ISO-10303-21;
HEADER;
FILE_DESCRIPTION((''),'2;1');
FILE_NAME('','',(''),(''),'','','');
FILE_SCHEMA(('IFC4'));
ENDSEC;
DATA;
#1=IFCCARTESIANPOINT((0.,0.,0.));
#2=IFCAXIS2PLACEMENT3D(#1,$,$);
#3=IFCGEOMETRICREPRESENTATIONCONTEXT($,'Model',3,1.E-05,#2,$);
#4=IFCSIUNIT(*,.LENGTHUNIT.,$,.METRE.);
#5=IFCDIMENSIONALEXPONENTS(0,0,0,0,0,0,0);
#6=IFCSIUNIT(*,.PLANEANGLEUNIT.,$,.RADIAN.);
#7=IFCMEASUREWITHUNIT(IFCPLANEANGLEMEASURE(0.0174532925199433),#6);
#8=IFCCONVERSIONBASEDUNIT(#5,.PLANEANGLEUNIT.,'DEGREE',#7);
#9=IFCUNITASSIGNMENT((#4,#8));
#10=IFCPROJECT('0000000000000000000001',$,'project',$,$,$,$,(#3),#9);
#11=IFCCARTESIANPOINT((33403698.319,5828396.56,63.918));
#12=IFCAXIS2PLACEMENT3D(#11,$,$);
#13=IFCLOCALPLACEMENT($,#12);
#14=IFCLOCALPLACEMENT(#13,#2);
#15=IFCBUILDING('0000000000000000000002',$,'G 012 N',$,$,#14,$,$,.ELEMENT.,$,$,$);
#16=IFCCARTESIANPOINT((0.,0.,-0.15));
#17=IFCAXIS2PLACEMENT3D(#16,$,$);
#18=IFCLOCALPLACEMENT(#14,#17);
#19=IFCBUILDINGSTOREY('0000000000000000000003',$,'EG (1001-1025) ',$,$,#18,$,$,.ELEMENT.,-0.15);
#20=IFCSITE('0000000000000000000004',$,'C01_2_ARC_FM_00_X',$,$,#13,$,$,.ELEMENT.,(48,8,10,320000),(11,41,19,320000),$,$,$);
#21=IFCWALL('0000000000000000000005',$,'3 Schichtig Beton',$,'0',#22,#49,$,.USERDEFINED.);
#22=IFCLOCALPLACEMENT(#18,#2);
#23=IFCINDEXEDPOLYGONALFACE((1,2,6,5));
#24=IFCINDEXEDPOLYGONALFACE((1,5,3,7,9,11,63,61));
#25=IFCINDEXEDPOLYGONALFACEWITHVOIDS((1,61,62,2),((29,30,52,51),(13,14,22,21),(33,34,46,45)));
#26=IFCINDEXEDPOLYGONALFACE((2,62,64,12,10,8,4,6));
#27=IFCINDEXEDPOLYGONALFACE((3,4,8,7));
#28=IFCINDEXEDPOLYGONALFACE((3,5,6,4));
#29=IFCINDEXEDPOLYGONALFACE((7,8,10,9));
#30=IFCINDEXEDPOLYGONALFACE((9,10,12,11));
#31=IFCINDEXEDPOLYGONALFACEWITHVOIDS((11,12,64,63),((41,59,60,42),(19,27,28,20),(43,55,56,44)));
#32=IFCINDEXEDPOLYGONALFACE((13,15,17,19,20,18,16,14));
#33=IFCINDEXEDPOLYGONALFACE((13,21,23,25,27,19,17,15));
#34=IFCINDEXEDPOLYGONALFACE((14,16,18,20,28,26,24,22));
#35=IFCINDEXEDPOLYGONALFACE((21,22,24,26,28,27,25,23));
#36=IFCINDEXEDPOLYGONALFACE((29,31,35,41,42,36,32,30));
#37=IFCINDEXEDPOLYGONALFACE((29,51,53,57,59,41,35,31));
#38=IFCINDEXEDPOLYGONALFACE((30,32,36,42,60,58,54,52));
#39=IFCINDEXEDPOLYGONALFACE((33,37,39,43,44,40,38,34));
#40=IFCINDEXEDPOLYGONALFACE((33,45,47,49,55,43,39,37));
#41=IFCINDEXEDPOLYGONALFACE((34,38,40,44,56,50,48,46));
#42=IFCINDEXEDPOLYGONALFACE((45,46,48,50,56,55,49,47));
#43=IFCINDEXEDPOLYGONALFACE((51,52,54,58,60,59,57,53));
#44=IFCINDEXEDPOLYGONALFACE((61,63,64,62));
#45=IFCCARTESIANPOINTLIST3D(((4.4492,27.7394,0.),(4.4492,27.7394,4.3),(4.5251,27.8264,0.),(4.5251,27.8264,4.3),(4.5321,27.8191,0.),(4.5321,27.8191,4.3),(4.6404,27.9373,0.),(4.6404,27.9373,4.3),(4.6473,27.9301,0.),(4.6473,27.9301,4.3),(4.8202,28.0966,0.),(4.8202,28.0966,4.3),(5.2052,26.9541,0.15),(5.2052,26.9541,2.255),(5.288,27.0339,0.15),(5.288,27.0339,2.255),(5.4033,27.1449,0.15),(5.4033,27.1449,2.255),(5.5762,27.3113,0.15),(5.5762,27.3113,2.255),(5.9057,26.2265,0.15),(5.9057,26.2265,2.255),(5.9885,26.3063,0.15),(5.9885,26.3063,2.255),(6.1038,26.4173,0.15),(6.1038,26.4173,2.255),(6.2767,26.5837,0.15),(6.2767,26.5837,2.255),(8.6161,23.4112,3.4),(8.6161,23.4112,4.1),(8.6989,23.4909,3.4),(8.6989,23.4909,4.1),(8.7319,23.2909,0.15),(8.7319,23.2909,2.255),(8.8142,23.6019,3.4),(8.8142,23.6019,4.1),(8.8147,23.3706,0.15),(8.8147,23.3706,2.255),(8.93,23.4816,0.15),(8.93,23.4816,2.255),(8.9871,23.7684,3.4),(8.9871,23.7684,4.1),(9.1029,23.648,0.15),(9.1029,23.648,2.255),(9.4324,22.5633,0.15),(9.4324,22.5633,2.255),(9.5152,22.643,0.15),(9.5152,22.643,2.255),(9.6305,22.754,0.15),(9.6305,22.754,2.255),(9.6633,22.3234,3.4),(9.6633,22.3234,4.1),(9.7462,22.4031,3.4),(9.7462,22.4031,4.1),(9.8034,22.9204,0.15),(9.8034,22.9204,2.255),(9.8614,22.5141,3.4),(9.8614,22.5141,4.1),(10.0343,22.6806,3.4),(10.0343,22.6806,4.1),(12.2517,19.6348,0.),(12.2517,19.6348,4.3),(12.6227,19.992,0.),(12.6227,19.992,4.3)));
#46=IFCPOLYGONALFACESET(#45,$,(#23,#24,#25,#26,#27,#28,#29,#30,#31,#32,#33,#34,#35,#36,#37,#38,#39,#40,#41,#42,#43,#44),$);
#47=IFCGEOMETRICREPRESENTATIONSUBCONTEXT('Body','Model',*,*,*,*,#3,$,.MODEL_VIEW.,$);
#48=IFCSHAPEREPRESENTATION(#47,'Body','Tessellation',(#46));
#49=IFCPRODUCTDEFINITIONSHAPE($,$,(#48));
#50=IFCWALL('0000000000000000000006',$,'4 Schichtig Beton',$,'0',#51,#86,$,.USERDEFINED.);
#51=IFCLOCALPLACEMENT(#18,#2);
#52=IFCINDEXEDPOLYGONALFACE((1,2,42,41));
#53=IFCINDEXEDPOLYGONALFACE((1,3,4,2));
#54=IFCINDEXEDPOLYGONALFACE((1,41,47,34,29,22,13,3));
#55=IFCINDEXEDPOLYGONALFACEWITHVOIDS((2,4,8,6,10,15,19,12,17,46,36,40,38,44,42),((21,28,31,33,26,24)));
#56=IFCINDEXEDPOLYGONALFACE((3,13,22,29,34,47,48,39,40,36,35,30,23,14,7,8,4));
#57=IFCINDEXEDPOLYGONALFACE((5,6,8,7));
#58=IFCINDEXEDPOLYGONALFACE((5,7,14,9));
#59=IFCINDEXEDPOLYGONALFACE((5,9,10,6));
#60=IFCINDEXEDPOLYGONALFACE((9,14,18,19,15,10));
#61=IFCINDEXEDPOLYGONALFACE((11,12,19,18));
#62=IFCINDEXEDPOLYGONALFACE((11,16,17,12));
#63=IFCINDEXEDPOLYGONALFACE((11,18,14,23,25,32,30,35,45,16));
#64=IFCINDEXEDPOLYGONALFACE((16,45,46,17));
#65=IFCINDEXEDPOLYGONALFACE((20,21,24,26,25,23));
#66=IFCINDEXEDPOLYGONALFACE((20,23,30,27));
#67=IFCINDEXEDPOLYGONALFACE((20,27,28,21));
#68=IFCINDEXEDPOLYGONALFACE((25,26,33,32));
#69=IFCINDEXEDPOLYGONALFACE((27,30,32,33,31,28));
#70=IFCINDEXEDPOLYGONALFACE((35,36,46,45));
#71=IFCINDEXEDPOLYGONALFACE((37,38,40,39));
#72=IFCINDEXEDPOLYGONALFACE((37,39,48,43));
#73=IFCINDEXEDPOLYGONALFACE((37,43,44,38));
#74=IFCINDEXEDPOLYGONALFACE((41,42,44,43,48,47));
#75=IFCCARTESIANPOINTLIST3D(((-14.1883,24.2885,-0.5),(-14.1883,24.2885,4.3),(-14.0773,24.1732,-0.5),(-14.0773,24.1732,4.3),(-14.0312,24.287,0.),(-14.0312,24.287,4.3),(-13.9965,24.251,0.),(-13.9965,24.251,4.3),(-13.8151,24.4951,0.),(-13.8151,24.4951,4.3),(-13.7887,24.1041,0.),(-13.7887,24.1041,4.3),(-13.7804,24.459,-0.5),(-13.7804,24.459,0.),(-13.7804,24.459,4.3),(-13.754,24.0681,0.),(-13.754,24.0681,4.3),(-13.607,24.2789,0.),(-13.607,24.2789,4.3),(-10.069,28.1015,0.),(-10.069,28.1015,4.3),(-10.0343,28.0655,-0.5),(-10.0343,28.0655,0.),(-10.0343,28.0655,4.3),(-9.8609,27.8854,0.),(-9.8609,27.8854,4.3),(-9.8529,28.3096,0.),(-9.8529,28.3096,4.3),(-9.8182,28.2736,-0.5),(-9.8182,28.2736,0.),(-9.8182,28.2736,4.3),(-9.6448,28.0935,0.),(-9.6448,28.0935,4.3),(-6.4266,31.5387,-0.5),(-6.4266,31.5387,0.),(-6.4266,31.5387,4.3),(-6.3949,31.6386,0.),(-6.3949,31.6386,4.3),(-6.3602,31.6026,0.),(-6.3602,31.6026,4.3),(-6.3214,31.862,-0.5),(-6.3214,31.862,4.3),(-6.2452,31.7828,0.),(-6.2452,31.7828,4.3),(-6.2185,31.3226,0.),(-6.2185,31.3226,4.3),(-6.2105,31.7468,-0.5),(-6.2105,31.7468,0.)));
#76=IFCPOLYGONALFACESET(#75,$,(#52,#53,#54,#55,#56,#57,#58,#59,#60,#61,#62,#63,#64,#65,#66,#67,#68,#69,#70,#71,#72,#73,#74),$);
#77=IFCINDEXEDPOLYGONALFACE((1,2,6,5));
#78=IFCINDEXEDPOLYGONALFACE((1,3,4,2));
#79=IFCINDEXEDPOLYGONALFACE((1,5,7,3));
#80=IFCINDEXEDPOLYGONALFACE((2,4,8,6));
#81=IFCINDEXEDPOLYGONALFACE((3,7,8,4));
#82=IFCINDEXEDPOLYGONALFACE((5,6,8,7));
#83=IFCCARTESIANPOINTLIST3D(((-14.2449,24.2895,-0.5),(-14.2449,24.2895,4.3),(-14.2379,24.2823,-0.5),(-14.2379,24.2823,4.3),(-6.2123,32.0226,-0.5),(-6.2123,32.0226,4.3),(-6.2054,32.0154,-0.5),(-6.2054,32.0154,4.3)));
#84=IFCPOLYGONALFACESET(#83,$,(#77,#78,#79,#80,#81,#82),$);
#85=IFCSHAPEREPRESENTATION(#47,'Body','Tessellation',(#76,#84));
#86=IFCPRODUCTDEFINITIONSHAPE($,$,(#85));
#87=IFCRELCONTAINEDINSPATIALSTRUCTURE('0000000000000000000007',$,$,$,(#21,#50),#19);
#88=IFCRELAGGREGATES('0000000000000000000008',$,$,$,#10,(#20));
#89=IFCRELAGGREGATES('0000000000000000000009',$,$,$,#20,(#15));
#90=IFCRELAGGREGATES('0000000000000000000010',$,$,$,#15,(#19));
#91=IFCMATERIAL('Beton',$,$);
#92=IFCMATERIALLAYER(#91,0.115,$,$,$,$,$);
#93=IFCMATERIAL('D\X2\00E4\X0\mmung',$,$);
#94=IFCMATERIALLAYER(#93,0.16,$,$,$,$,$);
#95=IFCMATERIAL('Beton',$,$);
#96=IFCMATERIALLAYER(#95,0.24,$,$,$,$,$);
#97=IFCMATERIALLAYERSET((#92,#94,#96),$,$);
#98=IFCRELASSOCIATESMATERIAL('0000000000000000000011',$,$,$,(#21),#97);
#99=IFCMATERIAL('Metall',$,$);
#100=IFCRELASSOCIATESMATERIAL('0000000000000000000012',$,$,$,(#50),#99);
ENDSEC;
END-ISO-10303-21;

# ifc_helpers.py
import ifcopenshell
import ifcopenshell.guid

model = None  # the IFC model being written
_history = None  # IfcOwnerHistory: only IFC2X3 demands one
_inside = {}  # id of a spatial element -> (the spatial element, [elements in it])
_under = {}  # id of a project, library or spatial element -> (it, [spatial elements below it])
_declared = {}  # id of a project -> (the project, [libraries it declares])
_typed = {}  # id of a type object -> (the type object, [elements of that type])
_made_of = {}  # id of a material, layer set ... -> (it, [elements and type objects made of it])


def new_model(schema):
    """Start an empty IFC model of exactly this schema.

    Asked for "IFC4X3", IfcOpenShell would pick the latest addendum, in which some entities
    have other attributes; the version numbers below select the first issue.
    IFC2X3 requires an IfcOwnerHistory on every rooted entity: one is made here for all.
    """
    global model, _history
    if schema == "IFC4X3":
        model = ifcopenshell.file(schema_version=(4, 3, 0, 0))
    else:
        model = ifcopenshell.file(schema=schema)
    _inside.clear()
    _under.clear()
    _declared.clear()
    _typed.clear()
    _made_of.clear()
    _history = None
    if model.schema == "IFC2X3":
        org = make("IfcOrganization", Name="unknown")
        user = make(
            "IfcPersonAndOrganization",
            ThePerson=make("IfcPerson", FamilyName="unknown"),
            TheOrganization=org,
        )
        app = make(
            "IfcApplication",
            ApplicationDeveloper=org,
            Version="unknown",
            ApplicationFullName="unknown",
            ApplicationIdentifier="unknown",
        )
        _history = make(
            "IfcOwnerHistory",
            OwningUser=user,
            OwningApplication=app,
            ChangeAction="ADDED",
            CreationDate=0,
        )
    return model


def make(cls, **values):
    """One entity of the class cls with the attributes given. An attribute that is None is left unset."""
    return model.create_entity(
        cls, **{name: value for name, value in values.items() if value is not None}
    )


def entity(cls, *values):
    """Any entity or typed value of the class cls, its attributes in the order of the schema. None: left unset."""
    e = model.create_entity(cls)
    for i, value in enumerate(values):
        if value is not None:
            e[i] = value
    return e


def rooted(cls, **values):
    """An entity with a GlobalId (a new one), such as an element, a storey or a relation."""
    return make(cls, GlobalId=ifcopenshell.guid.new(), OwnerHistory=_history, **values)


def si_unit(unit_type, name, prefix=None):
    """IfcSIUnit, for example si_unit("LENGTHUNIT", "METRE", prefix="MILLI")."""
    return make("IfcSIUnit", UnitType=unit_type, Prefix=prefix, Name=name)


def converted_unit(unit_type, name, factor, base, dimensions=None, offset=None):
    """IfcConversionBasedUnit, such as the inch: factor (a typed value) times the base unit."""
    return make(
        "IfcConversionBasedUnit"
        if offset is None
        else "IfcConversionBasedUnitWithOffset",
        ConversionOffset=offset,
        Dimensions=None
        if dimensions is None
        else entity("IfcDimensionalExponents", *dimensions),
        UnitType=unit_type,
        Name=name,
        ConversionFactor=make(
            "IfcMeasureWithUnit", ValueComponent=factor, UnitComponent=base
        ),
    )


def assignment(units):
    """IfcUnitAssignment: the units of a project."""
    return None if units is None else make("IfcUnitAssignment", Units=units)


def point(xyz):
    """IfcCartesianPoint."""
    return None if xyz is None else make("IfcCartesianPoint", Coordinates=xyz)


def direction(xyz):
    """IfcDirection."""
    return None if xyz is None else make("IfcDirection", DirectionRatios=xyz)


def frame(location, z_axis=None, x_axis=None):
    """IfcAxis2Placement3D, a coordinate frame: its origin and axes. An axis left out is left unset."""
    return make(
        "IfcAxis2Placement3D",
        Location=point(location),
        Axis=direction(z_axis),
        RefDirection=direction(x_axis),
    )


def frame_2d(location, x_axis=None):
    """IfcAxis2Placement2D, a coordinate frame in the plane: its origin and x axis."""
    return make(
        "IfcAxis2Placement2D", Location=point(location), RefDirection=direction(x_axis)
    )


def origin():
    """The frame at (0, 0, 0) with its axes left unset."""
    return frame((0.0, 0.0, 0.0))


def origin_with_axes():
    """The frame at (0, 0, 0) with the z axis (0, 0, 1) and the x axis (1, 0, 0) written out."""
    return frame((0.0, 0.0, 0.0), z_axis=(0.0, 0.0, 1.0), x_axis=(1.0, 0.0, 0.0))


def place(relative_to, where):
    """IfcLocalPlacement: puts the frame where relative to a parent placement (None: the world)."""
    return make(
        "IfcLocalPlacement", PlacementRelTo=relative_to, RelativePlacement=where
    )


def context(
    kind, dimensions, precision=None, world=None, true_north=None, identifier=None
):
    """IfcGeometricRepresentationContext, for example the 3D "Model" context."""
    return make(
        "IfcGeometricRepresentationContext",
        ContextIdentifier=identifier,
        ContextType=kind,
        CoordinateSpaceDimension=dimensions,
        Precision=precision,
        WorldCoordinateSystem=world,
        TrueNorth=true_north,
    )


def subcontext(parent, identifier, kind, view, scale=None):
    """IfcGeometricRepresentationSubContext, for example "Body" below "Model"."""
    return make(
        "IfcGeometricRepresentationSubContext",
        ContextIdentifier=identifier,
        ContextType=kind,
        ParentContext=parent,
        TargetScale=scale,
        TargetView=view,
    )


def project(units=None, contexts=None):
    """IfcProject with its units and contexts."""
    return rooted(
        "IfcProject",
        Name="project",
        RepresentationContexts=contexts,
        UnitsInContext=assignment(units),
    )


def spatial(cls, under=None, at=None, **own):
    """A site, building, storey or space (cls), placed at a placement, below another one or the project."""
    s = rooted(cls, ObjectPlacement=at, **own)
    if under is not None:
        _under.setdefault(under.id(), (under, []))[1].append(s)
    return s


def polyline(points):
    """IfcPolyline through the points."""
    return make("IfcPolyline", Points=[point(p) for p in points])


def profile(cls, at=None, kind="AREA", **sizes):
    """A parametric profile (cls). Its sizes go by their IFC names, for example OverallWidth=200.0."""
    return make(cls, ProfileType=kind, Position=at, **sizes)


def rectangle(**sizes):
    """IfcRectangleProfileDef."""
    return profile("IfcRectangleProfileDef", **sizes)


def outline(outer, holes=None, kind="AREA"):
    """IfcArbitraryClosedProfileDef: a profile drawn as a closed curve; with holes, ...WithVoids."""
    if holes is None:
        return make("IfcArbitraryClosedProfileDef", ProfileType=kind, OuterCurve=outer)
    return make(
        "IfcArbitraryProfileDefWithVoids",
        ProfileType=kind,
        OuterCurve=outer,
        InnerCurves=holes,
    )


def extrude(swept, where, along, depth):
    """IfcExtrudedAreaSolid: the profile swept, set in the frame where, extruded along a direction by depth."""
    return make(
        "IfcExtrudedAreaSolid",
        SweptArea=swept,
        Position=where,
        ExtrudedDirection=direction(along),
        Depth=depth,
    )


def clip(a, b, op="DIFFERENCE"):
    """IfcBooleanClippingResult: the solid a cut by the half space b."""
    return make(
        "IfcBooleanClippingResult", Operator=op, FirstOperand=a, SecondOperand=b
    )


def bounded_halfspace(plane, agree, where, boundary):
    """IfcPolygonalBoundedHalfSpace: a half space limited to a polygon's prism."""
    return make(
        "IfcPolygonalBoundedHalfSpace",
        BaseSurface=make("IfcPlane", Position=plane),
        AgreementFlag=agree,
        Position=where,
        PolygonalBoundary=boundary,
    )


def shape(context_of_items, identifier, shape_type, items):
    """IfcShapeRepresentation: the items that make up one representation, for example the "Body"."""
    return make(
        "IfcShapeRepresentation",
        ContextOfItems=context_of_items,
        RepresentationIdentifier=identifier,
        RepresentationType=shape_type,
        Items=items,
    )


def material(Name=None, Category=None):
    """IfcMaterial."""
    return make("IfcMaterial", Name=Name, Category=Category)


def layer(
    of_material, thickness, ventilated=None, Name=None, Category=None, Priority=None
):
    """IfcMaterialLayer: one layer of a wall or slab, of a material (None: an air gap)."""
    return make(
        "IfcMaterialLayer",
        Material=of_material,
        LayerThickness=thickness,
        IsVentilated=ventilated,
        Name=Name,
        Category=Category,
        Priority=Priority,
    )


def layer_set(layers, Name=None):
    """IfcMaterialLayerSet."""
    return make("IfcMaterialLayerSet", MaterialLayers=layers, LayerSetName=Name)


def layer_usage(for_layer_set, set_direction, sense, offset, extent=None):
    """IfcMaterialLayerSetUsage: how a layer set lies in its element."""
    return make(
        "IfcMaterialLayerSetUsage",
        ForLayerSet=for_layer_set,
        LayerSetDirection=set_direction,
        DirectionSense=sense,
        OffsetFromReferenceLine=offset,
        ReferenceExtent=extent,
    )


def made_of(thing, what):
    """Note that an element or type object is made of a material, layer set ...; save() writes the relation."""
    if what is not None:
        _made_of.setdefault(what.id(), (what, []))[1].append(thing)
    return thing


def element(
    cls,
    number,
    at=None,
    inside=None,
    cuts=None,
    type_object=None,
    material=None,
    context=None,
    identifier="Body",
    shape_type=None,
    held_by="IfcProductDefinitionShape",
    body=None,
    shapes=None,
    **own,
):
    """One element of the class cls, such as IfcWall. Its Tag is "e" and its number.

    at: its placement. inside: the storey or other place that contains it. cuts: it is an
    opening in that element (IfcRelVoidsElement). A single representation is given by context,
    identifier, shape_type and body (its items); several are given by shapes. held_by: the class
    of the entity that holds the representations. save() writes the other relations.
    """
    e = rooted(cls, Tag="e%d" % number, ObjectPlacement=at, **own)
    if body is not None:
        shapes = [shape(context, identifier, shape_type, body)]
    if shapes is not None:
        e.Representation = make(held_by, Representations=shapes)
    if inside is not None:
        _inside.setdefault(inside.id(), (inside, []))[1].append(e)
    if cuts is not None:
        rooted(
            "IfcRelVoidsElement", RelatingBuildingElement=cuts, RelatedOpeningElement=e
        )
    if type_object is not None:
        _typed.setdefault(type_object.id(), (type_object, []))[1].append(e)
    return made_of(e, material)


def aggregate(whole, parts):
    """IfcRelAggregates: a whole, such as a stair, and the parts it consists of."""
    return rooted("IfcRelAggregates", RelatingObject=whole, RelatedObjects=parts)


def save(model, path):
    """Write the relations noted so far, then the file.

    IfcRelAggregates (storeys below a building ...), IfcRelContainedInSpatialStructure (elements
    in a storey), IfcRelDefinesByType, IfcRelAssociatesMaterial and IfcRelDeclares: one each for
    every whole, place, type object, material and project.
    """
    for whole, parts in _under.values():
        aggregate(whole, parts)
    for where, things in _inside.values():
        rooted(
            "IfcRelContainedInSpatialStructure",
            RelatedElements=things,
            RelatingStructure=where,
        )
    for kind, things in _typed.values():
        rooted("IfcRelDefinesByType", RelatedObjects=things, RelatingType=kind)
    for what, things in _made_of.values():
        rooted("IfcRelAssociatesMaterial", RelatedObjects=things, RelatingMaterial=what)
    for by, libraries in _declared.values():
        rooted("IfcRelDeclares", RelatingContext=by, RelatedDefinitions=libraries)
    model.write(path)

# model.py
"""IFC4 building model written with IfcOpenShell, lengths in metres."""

from ifc_helpers import new_model, entity, si_unit, converted_unit, frame, frame_2d, origin, origin_with_axes, place, context, subcontext, project, spatial, polyline, rectangle, outline, extrude, clip, bounded_halfspace, material, layer, layer_set, layer_usage, element, save


model = new_model("IFC4")

# Units and contexts
model_context = context("Model", 3, precision=1e-05, world=origin())
body_context = subcontext(model_context, "Body", "Model", "MODEL_VIEW")
ifc_project = project(units=[si_unit("LENGTHUNIT", "METRE"), converted_unit("PLANEANGLEUNIT", "DEGREE", entity("IfcPlaneAngleMeasure", 0.0174532925199433), si_unit("PLANEANGLEUNIT", "RADIAN"), dimensions=[0, 0, 0, 0, 0, 0, 0])], contexts=[model_context])

# Site, building, storey
site_placement = place(None, frame((33403698.319, 5828396.56, 63.918)))
site = spatial("IfcSite", under=ifc_project, at=site_placement, Name="C01_2_ARC_FM_00_X", CompositionType="ELEMENT", RefLatitude=(48, 8, 10, 320000), RefLongitude=(11, 41, 19, 320000))
building_placement = place(site_placement, origin())
building = spatial("IfcBuilding", under=site, at=building_placement, Name="G 012 N", CompositionType="ELEMENT")
storey_placement = place(building_placement, frame((0.0, 0.0, -0.15)))
storey = spatial("IfcBuildingStorey", under=building, at=storey_placement, Name="EG (1001-1025) ", CompositionType="ELEMENT", Elevation=-0.15)

# Wall, openings
ifc_material_1 = material(Name="Beton")
ifc_layer_1 = layer(ifc_material_1, 0.115)
ifc_material_2 = material(Name="Dämmung")
ifc_layer_2 = layer(ifc_material_2, 0.16)
ifc_material_3 = material(Name="Beton")
ifc_layer_3 = layer(ifc_material_3, 0.24)
ifc_layer_set_1 = layer_set([ifc_layer_1, ifc_layer_2, ifc_layer_3])
ifc_layer_usage_1 = layer_usage(ifc_layer_set_1, "AXIS2", "POSITIVE", 0.0)
wall_1_placement = place(storey_placement, frame((4.4492, 27.7394, 0.0), z_axis=(0.0, 0.0, 1.0), x_axis=(0.693551, -0.720408, 0.0)))
wall_1 = element("IfcWall", 1, at=wall_1_placement, inside=storey, material=ifc_layer_usage_1, Name="3 Schichtig Beton", ObjectType="0", PredefinedType="USERDEFINED", context=body_context, shape_type="SweptSolid", body=[
    extrude(outline(polyline([(-5.8386, 6.1359), (-5.8386, 5.8959), (-5.8486, 5.8959), (-5.8486, 5.7359), (-5.8386, 5.7359), (-5.8386, 5.6209), (5.4114, 5.6209), (5.4114, 6.1359), (-5.8386, 6.1359)])), frame((5.8386, -5.6209, 0.0), z_axis=(0.0, 0.0, 1.0), x_axis=(1.0, 0.0, 0.0)), (0.0, 0.0, 1.0), 4.3),
])
opening_1_placement = place(wall_1_placement, frame((2.1, 0.115, 0.15), z_axis=(0.0, -1.0, 0.0), x_axis=(0.0, 0.0, 1.0)))
element("IfcOpeningElement", 2, at=opening_1_placement, cuts=wall_1, ObjectType="0", PredefinedType="USERDEFINED", context=body_context, shape_type="SweptSolid", body=[
    extrude(outline(polyline([(0.0, 1.01), (2.105, 1.01), (2.105, 0.0), (0.0, 0.0), (0.0, 1.01)])), origin_with_axes(), (0.0, 0.0, 1.0), 0.115),
    extrude(outline(polyline([(0.0, 1.01), (2.105, 1.01), (2.105, 0.0), (0.0, 0.0), (0.0, 1.01)])), frame((0.0, 0.0, -0.16), z_axis=(0.0, 0.0, 1.0), x_axis=(1.0, 0.0, 0.0)), (0.0, 0.0, 1.0), 0.16),
    extrude(outline(polyline([(0.0, 1.01), (2.105, 1.01), (2.105, 0.0), (0.0, 0.0), (0.0, 1.01)])), frame((0.0, 0.0, -0.4), z_axis=(0.0, 0.0, 1.0), x_axis=(1.0, 0.0, 0.0)), (0.0, 0.0, 1.0), 0.24),
])
opening_2_placement = place(wall_1_placement, frame((6.008, 0.0, 3.4), z_axis=(0.0, 1.0, 0.0), x_axis=(0.0, 0.0, 1.0)))
element("IfcOpeningElement", 3, at=opening_2_placement, cuts=wall_1, ObjectType="Opening", context=body_context, shape_type="SweptSolid", body=[
    extrude(outline(polyline([(0.0, 1.51), (0.7, 1.51), (0.7, 0.0), (0.0, 0.0), (0.0, 1.51)])), origin_with_axes(), (0.0, 0.0, 1.0), 0.115),
    extrude(outline(polyline([(0.0, 1.51), (0.7, 1.51), (0.7, 0.0), (0.0, 0.0), (0.0, 1.51)])), frame((0.0, 0.0, 0.115), z_axis=(0.0, 0.0, 1.0), x_axis=(1.0, 0.0, 0.0)), (0.0, 0.0, 1.0), 0.16),
    extrude(outline(polyline([(0.0, 1.51), (0.7, 1.51), (0.7, 0.0), (0.0, 0.0), (0.0, 1.51)])), frame((0.0, 0.0, 0.275), z_axis=(0.0, 0.0, 1.0), x_axis=(1.0, 0.0, 0.0)), (0.0, 0.0, 1.0), 0.24),
])
opening_3_placement = place(wall_1_placement, frame((7.185, 0.115, 0.15), z_axis=(0.0, -1.0, 0.0), x_axis=(0.0, 0.0, 1.0)))
element("IfcOpeningElement", 4, at=opening_3_placement, cuts=wall_1, ObjectType="0", PredefinedType="USERDEFINED", context=body_context, shape_type="SweptSolid", body=[
    extrude(outline(polyline([(0.0, 1.01), (2.105, 1.01), (2.105, 0.0), (0.0, 0.0), (0.0, 1.01)])), origin_with_axes(), (0.0, 0.0, 1.0), 0.115),
    extrude(outline(polyline([(0.0, 1.01), (2.105, 1.01), (2.105, 0.0), (0.0, 0.0), (0.0, 1.01)])), frame((0.0, 0.0, -0.16), z_axis=(0.0, 0.0, 1.0), x_axis=(1.0, 0.0, 0.0)), (0.0, 0.0, 1.0), 0.16),
    extrude(outline(polyline([(0.0, 1.01), (2.105, 1.01), (2.105, 0.0), (0.0, 0.0), (0.0, 1.01)])), frame((0.0, 0.0, -0.4), z_axis=(0.0, 0.0, 1.0), x_axis=(1.0, 0.0, 0.0)), (0.0, 0.0, 1.0), 0.24),
])

# Wall
ifc_material_4 = material(Name="Metall")
wall_2_placement = place(storey_placement, frame((-6.2123, 32.0226, -0.5), z_axis=(0.0, 0.0, 1.0), x_axis=(-0.720408, -0.693551, 0.0)))
element("IfcWall", 5, at=wall_2_placement, inside=storey, material=ifc_material_4, Name="4 Schichtig Beton", ObjectType="0", PredefinedType="USERDEFINED", context=body_context, shape_type="Clipping", body=[
    clip(clip(clip(clip(extrude(outline(polyline([(-0.1529, 0.0012), (-0.565, 0.0012), (-0.565, 0.2512), (-0.3129, 0.2512), (-0.3129, 0.3012), (-10.7729, 0.3012), (-10.7729, 0.0012), (-11.0729, 0.0012), (-11.0729, -0.1588), (-0.1529, -0.1588), (-0.1529, 0.0012)]), holes=[polyline([(-5.765, 0.0012), (-6.065, 0.0012), (-6.065, 0.2512), (-5.765, 0.2512), (-5.765, 0.0012)])]), frame((11.2629, 0.1988, 0.0), z_axis=(0.0, 0.0, 1.0), x_axis=(1.0, 0.0, 0.0)), (0.0, 0.0, 1.0), 4.8), bounded_halfspace(frame((6.5667, 0.36, 0.5), z_axis=(0.0, 0.0, 1.0), x_axis=(0.0, -1.0, 0.0)), True, origin_with_axes(), polyline([(5.4979, 0.45), (5.4979, 0.2), (10.6979, 0.2), (10.6979, 0.45), (10.95, 0.45), (10.95, 0.5), (0.49, 0.5), (0.49, 0.2), (5.1979, 0.2), (5.1979, 0.45), (5.4979, 0.45)]))), bounded_halfspace(frame((0.2939, 0.175, 0.5), z_axis=(0.0, 0.0, -1.0), x_axis=(-1.0, 0.0, 0.0)), True, origin_with_axes(), polyline([(0.3979, 0.2), (0.19, 0.2), (0.19, 0.15), (0.3979, 0.15), (0.3979, 0.2)]))), bounded_halfspace(frame((10.8479, 0.175, 0.5), z_axis=(0.0, 0.0, -1.0), x_axis=(0.0, 1.0, 0.0)), True, origin_with_axes(), polyline([(10.9979, 0.15), (10.9979, 0.2), (10.6979, 0.2), (10.6979, 0.15), (10.9979, 0.15)]))), bounded_halfspace(frame((5.3479, 0.175, 0.5), z_axis=(0.0, 0.0, -1.0), x_axis=(0.0, 1.0, 0.0)), True, origin_with_axes(), polyline([(5.4979, 0.15), (5.4979, 0.2), (5.1979, 0.2), (5.1979, 0.15), (5.4979, 0.15)]))),
    clip(clip(clip(clip(extrude(rectangle(XDim=11.15, YDim=0.01, at=frame_2d((-5.575, -0.005), x_axis=(-1.0, 0.0))), frame((11.15, 0.01, 0.0), z_axis=(0.0, 0.0, 1.0), x_axis=(1.0, 0.0, 0.0)), (0.0, 0.0, 1.0), 4.8), bounded_halfspace(frame((6.5667, 0.36, 0.5), z_axis=(0.0, 0.0, 1.0), x_axis=(0.0, -1.0, 0.0)), True, origin_with_axes(), polyline([(5.4979, 0.45), (5.4979, 0.2), (10.6979, 0.2), (10.6979, 0.45), (10.95, 0.45), (10.95, 0.5), (0.49, 0.5), (0.49, 0.2), (5.1979, 0.2), (5.1979, 0.45), (5.4979, 0.45)]))), bounded_halfspace(frame((0.2939, 0.175, 0.5), z_axis=(0.0, 0.0, -1.0), x_axis=(-1.0, 0.0, 0.0)), True, origin_with_axes(), polyline([(0.3979, 0.2), (0.19, 0.2), (0.19, 0.15), (0.3979, 0.15), (0.3979, 0.2)]))), bounded_halfspace(frame((10.8479, 0.175, 0.5), z_axis=(0.0, 0.0, -1.0), x_axis=(0.0, 1.0, 0.0)), True, origin_with_axes(), polyline([(10.9979, 0.15), (10.9979, 0.2), (10.6979, 0.2), (10.6979, 0.15), (10.9979, 0.15)]))), bounded_halfspace(frame((5.3479, 0.175, 0.5), z_axis=(0.0, 0.0, -1.0), x_axis=(0.0, 1.0, 0.0)), True, origin_with_axes(), polyline([(5.4979, 0.15), (5.4979, 0.2), (5.1979, 0.2), (5.1979, 0.15), (5.4979, 0.15)]))),
])

save(model, "model.ifc")
